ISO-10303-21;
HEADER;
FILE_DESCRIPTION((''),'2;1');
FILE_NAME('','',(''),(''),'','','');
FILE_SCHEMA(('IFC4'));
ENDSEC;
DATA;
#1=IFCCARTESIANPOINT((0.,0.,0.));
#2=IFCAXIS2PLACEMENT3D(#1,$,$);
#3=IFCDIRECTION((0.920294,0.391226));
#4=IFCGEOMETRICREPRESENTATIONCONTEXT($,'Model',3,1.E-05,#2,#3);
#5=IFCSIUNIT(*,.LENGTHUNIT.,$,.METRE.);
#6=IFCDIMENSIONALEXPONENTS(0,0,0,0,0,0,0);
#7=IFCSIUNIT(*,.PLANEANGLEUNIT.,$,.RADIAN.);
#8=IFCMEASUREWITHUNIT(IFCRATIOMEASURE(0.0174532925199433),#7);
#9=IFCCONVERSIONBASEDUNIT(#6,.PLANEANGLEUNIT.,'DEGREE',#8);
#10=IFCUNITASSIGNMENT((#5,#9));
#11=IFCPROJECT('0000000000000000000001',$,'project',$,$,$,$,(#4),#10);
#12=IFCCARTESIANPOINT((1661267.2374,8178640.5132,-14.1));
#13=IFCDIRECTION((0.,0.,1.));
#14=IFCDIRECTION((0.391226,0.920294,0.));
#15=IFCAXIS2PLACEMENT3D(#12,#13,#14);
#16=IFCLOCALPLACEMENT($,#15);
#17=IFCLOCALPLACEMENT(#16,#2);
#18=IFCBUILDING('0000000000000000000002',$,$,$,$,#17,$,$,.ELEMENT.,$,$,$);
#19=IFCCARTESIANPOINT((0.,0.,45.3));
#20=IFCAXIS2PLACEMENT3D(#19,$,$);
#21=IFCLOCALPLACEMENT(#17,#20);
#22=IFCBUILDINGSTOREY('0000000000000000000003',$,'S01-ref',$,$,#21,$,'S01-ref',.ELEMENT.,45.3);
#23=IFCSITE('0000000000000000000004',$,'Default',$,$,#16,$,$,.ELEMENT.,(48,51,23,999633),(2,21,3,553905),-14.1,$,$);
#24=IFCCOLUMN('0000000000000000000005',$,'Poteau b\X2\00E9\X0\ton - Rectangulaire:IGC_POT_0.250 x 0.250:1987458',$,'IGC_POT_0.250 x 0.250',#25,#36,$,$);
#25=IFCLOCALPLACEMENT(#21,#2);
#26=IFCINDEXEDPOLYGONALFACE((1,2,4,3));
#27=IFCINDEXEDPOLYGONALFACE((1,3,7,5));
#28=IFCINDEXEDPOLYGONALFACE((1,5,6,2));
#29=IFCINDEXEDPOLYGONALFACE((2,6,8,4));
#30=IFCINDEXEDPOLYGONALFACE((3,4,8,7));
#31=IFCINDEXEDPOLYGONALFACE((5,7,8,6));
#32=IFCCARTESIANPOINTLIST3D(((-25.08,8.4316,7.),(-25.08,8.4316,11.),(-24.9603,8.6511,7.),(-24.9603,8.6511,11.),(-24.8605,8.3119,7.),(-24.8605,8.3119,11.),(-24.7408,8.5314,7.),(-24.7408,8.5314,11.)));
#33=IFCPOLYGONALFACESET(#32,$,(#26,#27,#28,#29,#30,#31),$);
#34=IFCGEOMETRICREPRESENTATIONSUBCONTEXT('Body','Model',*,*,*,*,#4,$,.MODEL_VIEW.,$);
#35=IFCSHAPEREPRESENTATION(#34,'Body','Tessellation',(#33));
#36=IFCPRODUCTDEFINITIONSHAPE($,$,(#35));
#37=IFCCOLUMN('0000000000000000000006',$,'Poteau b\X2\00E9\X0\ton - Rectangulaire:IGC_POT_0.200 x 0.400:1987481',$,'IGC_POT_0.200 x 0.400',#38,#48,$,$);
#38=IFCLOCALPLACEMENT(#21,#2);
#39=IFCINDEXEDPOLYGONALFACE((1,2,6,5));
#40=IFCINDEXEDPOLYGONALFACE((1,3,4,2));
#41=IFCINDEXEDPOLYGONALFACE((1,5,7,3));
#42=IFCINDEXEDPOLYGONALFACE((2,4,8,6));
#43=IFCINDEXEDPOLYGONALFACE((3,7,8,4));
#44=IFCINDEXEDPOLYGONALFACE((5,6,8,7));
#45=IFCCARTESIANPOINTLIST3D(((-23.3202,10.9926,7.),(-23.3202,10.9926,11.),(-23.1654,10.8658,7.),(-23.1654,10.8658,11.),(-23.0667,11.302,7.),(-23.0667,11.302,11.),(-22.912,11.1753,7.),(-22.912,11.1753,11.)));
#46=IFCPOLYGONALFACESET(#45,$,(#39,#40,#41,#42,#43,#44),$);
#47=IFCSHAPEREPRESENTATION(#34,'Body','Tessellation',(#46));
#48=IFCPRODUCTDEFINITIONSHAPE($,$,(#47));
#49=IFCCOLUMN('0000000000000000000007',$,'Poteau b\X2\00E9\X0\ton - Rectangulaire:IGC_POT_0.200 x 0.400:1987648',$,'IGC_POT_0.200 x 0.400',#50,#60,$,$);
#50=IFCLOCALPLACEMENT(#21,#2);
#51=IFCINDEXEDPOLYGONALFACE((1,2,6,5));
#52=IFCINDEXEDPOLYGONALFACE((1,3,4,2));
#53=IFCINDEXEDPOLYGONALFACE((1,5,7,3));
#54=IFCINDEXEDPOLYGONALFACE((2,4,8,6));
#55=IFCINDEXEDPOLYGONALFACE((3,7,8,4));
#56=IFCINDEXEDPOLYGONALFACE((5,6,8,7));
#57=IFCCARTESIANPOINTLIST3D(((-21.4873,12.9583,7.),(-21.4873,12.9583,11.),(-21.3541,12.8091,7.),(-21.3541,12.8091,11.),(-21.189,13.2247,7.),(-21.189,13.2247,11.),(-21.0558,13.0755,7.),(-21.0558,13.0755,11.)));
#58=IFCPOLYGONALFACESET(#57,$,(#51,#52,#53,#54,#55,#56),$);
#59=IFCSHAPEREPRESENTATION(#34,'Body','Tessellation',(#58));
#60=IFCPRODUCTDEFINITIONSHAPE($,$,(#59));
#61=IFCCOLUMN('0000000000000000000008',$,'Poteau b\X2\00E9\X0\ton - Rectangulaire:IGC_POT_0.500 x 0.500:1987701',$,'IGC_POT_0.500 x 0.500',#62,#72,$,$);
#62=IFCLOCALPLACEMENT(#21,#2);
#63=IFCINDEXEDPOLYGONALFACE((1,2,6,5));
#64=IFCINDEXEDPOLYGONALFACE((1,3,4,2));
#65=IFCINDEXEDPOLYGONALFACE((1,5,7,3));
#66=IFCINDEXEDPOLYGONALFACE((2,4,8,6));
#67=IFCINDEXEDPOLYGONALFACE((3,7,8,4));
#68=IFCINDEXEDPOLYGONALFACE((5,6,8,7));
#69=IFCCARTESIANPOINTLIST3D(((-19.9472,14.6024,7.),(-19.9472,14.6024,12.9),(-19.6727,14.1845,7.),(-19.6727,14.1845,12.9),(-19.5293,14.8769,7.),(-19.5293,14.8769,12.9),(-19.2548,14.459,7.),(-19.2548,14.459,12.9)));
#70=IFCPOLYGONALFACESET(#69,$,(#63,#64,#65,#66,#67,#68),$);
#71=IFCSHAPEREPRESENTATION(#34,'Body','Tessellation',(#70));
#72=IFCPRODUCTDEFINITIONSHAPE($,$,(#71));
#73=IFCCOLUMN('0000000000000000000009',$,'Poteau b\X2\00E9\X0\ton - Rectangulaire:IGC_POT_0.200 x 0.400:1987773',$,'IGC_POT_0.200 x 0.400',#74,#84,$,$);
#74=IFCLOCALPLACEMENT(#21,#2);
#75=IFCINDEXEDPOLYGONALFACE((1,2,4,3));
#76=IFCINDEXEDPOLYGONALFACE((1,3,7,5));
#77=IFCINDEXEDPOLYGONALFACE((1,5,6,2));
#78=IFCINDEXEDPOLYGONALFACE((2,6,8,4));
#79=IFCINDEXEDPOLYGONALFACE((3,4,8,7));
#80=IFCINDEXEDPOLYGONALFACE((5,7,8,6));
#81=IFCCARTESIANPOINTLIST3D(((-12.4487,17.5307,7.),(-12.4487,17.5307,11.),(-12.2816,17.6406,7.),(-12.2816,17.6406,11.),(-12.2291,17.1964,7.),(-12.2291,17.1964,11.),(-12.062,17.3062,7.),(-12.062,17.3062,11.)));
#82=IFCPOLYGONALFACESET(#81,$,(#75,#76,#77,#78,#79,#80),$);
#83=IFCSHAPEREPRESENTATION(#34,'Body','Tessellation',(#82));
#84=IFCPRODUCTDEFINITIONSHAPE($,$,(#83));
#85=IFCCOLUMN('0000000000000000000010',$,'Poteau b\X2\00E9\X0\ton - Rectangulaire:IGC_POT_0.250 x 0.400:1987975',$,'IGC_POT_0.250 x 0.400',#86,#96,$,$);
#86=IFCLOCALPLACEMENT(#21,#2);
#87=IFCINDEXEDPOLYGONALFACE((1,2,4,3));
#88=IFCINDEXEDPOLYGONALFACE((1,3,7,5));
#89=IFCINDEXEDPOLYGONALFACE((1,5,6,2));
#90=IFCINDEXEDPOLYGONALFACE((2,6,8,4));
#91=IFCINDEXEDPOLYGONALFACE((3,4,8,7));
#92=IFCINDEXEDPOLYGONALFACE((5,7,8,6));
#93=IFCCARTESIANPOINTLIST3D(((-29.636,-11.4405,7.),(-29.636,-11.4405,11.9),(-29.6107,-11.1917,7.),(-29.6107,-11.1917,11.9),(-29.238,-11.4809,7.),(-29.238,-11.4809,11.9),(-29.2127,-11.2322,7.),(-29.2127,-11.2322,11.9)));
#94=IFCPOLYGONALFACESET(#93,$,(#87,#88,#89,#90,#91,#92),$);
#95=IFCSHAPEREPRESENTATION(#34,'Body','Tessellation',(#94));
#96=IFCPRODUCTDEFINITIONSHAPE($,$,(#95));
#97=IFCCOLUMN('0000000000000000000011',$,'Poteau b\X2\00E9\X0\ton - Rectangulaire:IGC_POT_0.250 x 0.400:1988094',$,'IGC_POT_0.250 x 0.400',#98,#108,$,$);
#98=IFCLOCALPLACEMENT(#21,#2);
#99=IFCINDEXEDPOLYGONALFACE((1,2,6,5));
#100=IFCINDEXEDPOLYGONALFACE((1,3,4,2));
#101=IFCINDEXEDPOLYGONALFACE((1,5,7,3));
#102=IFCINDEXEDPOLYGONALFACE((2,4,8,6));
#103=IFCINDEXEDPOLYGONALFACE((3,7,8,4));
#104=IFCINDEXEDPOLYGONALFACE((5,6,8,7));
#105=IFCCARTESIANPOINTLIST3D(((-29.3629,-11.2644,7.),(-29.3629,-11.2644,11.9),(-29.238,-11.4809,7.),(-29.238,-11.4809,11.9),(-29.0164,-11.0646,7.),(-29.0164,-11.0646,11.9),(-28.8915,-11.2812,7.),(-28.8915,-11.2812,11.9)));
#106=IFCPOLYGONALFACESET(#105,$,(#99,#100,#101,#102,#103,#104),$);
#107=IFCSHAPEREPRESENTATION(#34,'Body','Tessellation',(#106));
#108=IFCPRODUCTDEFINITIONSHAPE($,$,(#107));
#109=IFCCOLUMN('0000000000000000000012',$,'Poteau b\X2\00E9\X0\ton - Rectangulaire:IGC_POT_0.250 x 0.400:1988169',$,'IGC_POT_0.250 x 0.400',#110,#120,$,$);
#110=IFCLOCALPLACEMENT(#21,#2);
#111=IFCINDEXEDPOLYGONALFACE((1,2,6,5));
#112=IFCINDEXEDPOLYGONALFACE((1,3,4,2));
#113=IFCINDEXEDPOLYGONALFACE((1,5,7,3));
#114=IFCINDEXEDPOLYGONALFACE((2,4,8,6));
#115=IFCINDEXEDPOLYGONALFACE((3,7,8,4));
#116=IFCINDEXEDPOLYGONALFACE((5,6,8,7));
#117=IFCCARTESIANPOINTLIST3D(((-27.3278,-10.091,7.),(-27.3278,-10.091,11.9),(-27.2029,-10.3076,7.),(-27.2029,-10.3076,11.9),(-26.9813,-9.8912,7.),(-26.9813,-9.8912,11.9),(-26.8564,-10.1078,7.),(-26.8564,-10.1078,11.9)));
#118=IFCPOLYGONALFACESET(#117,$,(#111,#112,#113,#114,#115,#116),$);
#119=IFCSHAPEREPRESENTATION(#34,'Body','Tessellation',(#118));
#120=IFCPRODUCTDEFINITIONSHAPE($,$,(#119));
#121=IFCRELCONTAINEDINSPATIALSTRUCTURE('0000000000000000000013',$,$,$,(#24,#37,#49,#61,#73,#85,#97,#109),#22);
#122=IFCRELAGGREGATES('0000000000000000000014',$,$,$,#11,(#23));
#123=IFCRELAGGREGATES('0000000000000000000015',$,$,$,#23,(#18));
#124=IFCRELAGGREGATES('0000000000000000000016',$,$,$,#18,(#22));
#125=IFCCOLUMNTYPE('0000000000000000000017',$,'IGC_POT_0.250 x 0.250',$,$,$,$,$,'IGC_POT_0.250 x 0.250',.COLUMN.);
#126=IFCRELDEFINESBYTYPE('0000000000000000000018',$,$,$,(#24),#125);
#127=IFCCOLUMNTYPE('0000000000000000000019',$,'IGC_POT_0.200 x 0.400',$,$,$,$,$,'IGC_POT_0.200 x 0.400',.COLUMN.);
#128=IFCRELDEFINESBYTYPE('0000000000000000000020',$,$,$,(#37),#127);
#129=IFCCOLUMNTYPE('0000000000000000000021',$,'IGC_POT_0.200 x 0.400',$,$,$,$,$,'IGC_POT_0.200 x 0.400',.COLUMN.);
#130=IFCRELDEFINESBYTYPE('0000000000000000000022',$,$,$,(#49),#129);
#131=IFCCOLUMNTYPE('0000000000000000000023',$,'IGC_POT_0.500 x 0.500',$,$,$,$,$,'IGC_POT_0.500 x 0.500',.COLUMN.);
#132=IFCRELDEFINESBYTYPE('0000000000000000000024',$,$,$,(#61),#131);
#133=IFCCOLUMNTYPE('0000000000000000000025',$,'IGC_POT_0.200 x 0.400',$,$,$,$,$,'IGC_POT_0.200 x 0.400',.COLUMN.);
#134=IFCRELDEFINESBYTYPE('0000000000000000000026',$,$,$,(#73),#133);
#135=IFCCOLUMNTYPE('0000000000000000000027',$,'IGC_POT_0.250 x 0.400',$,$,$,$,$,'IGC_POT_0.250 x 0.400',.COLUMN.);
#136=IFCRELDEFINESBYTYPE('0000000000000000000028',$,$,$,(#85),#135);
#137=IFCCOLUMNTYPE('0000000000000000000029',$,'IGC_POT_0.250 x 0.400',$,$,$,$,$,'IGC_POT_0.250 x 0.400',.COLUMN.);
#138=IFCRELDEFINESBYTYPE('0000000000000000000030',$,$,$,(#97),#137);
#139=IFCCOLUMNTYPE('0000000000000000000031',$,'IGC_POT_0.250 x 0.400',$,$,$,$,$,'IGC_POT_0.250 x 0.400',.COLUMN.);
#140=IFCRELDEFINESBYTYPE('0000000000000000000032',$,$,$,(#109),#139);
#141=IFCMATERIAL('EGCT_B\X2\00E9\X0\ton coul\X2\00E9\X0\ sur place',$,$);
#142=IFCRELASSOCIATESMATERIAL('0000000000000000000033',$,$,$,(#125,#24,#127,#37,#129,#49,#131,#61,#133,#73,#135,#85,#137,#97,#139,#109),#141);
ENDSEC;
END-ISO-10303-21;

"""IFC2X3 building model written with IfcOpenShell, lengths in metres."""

from ifc_helpers import new_model, entity, si_unit, converted_unit, direction, frame, frame_2d, origin, origin_2d_with_axis, place, context, subcontext, project, spatial, rectangle, extrude, source, transform, mapped, material, type_object, type_shapes, element, save


model = new_model("IFC2X3")

# Units and contexts
model_context = context("Model", 3, precision=1e-05, world=origin(), true_north=direction((0.920294, 0.391226)))
body_context = subcontext(model_context, "Body", "Model", "MODEL_VIEW")
ifc_project = project(units=[si_unit("LENGTHUNIT", "METRE"), converted_unit("PLANEANGLEUNIT", "DEGREE", entity("IfcRatioMeasure", 0.0174532925199433), si_unit("PLANEANGLEUNIT", "RADIAN"), dimensions=[0, 0, 0, 0, 0, 0, 0])], contexts=[model_context])

# Site, building, storey
site_placement = place(None, frame((1661267.2374, 8178640.5132, -14.1), z_axis=(0.0, 0.0, 1.0), x_axis=(0.391226, 0.920294, 0.0)))
site = spatial("IfcSite", under=ifc_project, at=site_placement, Name="Default", CompositionType="ELEMENT", RefLatitude=(48, 51, 23, 999633), RefLongitude=(2, 21, 3, 553905), RefElevation=-14.1)
building_placement = place(site_placement, origin())
building = spatial("IfcBuilding", under=site, at=building_placement, CompositionType="ELEMENT")
storey_placement = place(building_placement, frame((0.0, 0.0, 45.3)))
storey = spatial("IfcBuildingStorey", under=building, at=storey_placement, Name="S01-ref", LongName="S01-ref", CompositionType="ELEMENT", Elevation=45.3)

# Columns
ifc_material = material(Name="EGCT_Béton coulé sur place")
column_type_1 = type_object("IfcColumnType", Name="IGC_POT_0.250 x 0.250", ElementType="IGC_POT_0.250 x 0.250", PredefinedType="COLUMN", material=ifc_material)
shared_shape_1 = source(origin(), body_context, "Body", "SweptSolid", [
    extrude(rectangle(XDim=0.25, YDim=0.25, at=origin_2d_with_axis()), frame((-24.9104, 8.4815, 52.3), z_axis=(0.0, 0.0, 1.0), x_axis=(0.478796, 0.877926, 0.0)), (0.0, 0.0, 1.0), 4.0),
])
type_shapes(column_type_1, [shared_shape_1])
column_1_placement = place(storey_placement, frame((0.0, 0.0, -45.3)))
element("IfcColumn", 1, at=column_1_placement, inside=storey, type_object=column_type_1, material=ifc_material, Name="Poteau béton - Rectangulaire:IGC_POT_0.250 x 0.250:1987458", ObjectType="IGC_POT_0.250 x 0.250", context=body_context, shape_type="MappedRepresentation", body=[
    mapped(shared_shape_1, transform((0.0, 0.0, 0.0), scale=1.0)),
])
column_type_2 = type_object("IfcColumnType", Name="IGC_POT_0.200 x 0.400", ElementType="IGC_POT_0.200 x 0.400", PredefinedType="COLUMN", material=ifc_material)
shared_shape_2 = source(origin(), body_context, "Body", "SweptSolid", [
    extrude(rectangle(XDim=0.2, YDim=0.4, at=origin_2d_with_axis()), frame((-23.1161, 11.0839, 52.3), z_axis=(0.0, 0.0, 1.0), x_axis=(-0.77367, 0.633588, 0.0)), (0.0, 0.0, 1.0), 4.0),
])
type_shapes(column_type_2, [shared_shape_2])
column_2_placement = place(storey_placement, frame((0.0, 0.0, -45.3)))
element("IfcColumn", 2, at=column_2_placement, inside=storey, type_object=column_type_2, material=ifc_material, Name="Poteau béton - Rectangulaire:IGC_POT_0.200 x 0.400:1987481", ObjectType="IGC_POT_0.200 x 0.400", context=body_context, shape_type="MappedRepresentation", body=[
    mapped(shared_shape_2, transform((0.0, 0.0, 0.0), scale=1.0)),
])
column_type_3 = type_object("IfcColumnType", Name="IGC_POT_0.200 x 0.400", ElementType="IGC_POT_0.200 x 0.400", PredefinedType="COLUMN", material=ifc_material)
shared_shape_3 = source(origin(), body_context, "Body", "SweptSolid", [
    extrude(rectangle(XDim=0.2, YDim=0.4, at=origin_2d_with_axis()), frame((-21.2716, 13.0169, 52.3), z_axis=(0.0, 0.0, 1.0), x_axis=(-0.666011, 0.745942, 0.0)), (0.0, 0.0, 1.0), 4.0),
])
type_shapes(column_type_3, [shared_shape_3])
column_3_placement = place(storey_placement, frame((0.0, 0.0, -45.3)))
element("IfcColumn", 3, at=column_3_placement, inside=storey, type_object=column_type_3, material=ifc_material, Name="Poteau béton - Rectangulaire:IGC_POT_0.200 x 0.400:1987648", ObjectType="IGC_POT_0.200 x 0.400", context=body_context, shape_type="MappedRepresentation", body=[
    mapped(shared_shape_3, transform((0.0, 0.0, 0.0), scale=1.0)),
])
column_type_4 = type_object("IfcColumnType", Name="IGC_POT_0.500 x 0.500", ElementType="IGC_POT_0.500 x 0.500", PredefinedType="COLUMN", material=ifc_material)
shared_shape_4 = source(origin(), body_context, "Body", "SweptSolid", [
    extrude(rectangle(XDim=0.5, YDim=0.5, at=origin_2d_with_axis()), frame((-19.601, 14.5307, 52.3), z_axis=(0.0, 0.0, 1.0), x_axis=(-0.549039, 0.835797, 0.0)), (0.0, 0.0, 1.0), 5.9),
])
type_shapes(column_type_4, [shared_shape_4])
column_4_placement = place(storey_placement, frame((0.0, 0.0, -45.3)))
element("IfcColumn", 4, at=column_4_placement, inside=storey, type_object=column_type_4, material=ifc_material, Name="Poteau béton - Rectangulaire:IGC_POT_0.500 x 0.500:1987701", ObjectType="IGC_POT_0.500 x 0.500", context=body_context, shape_type="MappedRepresentation", body=[
    mapped(shared_shape_4, transform((0.0, 0.0, 0.0), scale=1.0)),
])
column_type_5 = type_object("IfcColumnType", Name="IGC_POT_0.200 x 0.400", ElementType="IGC_POT_0.200 x 0.400", PredefinedType="COLUMN", material=ifc_material)
shared_shape_5 = source(origin(), body_context, "Body", "SweptSolid", [
    extrude(rectangle(XDim=0.4, YDim=0.2, at=frame_2d((0.0, 0.0), x_axis=(1.0, 0.0))), frame((-12.2553, 17.4185, 52.3), z_axis=(0.0, 0.0, 1.0), x_axis=(-0.549039, 0.835797, 0.0)), (0.0, 0.0, 1.0), 4.0),
])
type_shapes(column_type_5, [shared_shape_5])
column_5_placement = place(storey_placement, frame((0.0, 0.0, -45.3)))
element("IfcColumn", 5, at=column_5_placement, inside=storey, type_object=column_type_5, material=ifc_material, Name="Poteau béton - Rectangulaire:IGC_POT_0.200 x 0.400:1987773", ObjectType="IGC_POT_0.200 x 0.400", context=body_context, shape_type="MappedRepresentation", body=[
    mapped(shared_shape_5, transform((0.0, 0.0, 0.0), scale=1.0)),
])
column_type_6 = type_object("IfcColumnType", Name="IGC_POT_0.250 x 0.400", ElementType="IGC_POT_0.250 x 0.400", PredefinedType="COLUMN", material=ifc_material)
shared_shape_6 = source(origin(), body_context, "Body", "SweptSolid", [
    extrude(rectangle(XDim=0.25, YDim=0.4, at=origin_2d_with_axis()), frame((-29.4243, -11.3363, 52.3), z_axis=(0.0, 0.0, 1.0), x_axis=(0.101222, 0.994864, 0.0)), (0.0, 0.0, 1.0), 4.9),
])
type_shapes(column_type_6, [shared_shape_6])
column_6_placement = place(storey_placement, frame((0.0, 0.0, -45.3)))
element("IfcColumn", 6, at=column_6_placement, inside=storey, type_object=column_type_6, material=ifc_material, Name="Poteau béton - Rectangulaire:IGC_POT_0.250 x 0.400:1987975", ObjectType="IGC_POT_0.250 x 0.400", context=body_context, shape_type="MappedRepresentation", body=[
    mapped(shared_shape_6, transform((0.0, 0.0, 0.0), scale=1.0)),
])
column_type_7 = type_object("IfcColumnType", Name="IGC_POT_0.250 x 0.400", ElementType="IGC_POT_0.250 x 0.400", PredefinedType="COLUMN", material=ifc_material)
shared_shape_7 = source(origin(), body_context, "Body", "SweptSolid", [
    extrude(rectangle(XDim=0.25, YDim=0.4, at=frame_2d((0.0, 0.0), x_axis=(1.0, 0.0))), frame((-29.1272, -11.2728, 52.3), z_axis=(0.0, 0.0, 1.0), x_axis=(-0.49948, 0.866326, 0.0)), (0.0, 0.0, 1.0), 4.9),
])
type_shapes(column_type_7, [shared_shape_7])
column_7_placement = place(storey_placement, frame((0.0, 0.0, -45.3)))
element("IfcColumn", 7, at=column_7_placement, inside=storey, type_object=column_type_7, material=ifc_material, Name="Poteau béton - Rectangulaire:IGC_POT_0.250 x 0.400:1988094", ObjectType="IGC_POT_0.250 x 0.400", context=body_context, shape_type="MappedRepresentation", body=[
    mapped(shared_shape_7, transform((0.0, 0.0, 0.0), scale=1.0)),
])
column_type_8 = type_object("IfcColumnType", Name="IGC_POT_0.250 x 0.400", ElementType="IGC_POT_0.250 x 0.400", PredefinedType="COLUMN", material=ifc_material)
shared_shape_8 = source(origin(), body_context, "Body", "SweptSolid", [
    extrude(rectangle(XDim=0.25, YDim=0.4, at=frame_2d((0.0, 0.0), x_axis=(1.0, 0.0))), frame((-27.0921, -10.0994, 52.3), z_axis=(0.0, 0.0, 1.0), x_axis=(-0.49948, 0.866326, 0.0)), (0.0, 0.0, 1.0), 4.9),
])
type_shapes(column_type_8, [shared_shape_8])
column_8_placement = place(storey_placement, frame((0.0, 0.0, -45.3)))
element("IfcColumn", 8, at=column_8_placement, inside=storey, type_object=column_type_8, material=ifc_material, Name="Poteau béton - Rectangulaire:IGC_POT_0.250 x 0.400:1988169", ObjectType="IGC_POT_0.250 x 0.400", context=body_context, shape_type="MappedRepresentation", body=[
    mapped(shared_shape_8, transform((0.0, 0.0, 0.0), scale=1.0)),
])

save(model, "model.ifc")
